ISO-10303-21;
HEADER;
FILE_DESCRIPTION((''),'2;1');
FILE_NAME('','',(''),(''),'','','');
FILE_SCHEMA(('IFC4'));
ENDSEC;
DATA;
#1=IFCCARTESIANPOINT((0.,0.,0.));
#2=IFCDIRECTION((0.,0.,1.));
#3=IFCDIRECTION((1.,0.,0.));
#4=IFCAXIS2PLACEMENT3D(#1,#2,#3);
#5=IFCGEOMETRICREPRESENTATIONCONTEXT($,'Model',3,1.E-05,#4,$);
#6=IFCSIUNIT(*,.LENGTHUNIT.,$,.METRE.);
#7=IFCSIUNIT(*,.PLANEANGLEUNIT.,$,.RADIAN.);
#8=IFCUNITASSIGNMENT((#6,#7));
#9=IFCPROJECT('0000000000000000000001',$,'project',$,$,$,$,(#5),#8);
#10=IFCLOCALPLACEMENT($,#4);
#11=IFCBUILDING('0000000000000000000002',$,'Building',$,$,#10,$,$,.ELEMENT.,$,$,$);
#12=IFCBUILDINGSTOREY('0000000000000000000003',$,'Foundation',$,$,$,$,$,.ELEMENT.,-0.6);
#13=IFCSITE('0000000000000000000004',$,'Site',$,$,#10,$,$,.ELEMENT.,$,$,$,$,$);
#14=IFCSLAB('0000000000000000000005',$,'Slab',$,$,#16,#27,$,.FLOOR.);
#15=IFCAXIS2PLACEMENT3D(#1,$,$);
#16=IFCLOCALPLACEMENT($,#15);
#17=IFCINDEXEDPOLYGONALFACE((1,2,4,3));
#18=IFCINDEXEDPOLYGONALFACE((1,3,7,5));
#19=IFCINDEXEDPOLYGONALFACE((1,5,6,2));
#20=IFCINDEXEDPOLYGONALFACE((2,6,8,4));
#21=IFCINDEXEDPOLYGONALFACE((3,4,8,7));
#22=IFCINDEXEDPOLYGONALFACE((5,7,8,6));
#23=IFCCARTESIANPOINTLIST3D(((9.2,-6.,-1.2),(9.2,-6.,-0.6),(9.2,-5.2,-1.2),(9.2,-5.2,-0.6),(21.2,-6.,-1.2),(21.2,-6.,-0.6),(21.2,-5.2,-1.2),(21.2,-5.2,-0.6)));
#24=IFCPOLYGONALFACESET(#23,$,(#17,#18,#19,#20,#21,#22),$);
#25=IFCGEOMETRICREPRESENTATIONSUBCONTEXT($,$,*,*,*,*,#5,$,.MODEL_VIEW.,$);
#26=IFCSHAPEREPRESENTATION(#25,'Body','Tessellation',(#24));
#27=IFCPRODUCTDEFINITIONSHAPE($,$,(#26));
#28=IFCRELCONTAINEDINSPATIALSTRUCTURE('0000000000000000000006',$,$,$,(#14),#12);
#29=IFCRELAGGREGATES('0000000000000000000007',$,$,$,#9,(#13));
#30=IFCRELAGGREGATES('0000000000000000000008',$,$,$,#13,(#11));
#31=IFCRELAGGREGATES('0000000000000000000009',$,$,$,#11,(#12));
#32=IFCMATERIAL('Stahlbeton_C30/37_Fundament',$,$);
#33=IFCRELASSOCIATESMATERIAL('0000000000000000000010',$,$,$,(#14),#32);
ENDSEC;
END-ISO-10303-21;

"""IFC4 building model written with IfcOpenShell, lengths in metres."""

from ifc_helpers import new_model, si_unit, frame, frame_2d, origin, origin_with_axes, place, context, subcontext, project, spatial, rectangle, extrude, material, element, save


model = new_model("IFC4")

# Units and contexts
model_context = context("Model", 3, precision=1e-05, world=origin_with_axes())
sub_context = subcontext(model_context, None, None, "MODEL_VIEW")
ifc_project = project(units=[si_unit("LENGTHUNIT", "METRE"), si_unit("PLANEANGLEUNIT", "RADIAN")], contexts=[model_context])

# Site, building, storey
placement_1 = place(None, origin_with_axes())
site = spatial("IfcSite", under=ifc_project, at=placement_1, Name="Site", CompositionType="ELEMENT")
building = spatial("IfcBuilding", under=site, at=placement_1, Name="Building", CompositionType="ELEMENT")
storey = spatial("IfcBuildingStorey", under=building, Name="Foundation", CompositionType="ELEMENT", Elevation=-0.6)

# Slab
ifc_material = material(Name="Stahlbeton_C30/37_Fundament")
placement_2 = place(None, origin_with_axes())
placement_3 = place(placement_2, frame((0.0, 0.0, -0.6)))
slab_placement = place(placement_3, frame((9.2, -6.0, -0.6)))
element("IfcSlab", 1, at=slab_placement, inside=storey, material=ifc_material, Name="Slab", PredefinedType="FLOOR", context=sub_context, shape_type="SweptSolid", body=[
    extrude(rectangle(XDim=12.0, YDim=0.8, at=frame_2d((6.0, 0.4))), origin(), (0.0, 0.0, 1.0), 0.6),
])

save(model, "model.ifc")
